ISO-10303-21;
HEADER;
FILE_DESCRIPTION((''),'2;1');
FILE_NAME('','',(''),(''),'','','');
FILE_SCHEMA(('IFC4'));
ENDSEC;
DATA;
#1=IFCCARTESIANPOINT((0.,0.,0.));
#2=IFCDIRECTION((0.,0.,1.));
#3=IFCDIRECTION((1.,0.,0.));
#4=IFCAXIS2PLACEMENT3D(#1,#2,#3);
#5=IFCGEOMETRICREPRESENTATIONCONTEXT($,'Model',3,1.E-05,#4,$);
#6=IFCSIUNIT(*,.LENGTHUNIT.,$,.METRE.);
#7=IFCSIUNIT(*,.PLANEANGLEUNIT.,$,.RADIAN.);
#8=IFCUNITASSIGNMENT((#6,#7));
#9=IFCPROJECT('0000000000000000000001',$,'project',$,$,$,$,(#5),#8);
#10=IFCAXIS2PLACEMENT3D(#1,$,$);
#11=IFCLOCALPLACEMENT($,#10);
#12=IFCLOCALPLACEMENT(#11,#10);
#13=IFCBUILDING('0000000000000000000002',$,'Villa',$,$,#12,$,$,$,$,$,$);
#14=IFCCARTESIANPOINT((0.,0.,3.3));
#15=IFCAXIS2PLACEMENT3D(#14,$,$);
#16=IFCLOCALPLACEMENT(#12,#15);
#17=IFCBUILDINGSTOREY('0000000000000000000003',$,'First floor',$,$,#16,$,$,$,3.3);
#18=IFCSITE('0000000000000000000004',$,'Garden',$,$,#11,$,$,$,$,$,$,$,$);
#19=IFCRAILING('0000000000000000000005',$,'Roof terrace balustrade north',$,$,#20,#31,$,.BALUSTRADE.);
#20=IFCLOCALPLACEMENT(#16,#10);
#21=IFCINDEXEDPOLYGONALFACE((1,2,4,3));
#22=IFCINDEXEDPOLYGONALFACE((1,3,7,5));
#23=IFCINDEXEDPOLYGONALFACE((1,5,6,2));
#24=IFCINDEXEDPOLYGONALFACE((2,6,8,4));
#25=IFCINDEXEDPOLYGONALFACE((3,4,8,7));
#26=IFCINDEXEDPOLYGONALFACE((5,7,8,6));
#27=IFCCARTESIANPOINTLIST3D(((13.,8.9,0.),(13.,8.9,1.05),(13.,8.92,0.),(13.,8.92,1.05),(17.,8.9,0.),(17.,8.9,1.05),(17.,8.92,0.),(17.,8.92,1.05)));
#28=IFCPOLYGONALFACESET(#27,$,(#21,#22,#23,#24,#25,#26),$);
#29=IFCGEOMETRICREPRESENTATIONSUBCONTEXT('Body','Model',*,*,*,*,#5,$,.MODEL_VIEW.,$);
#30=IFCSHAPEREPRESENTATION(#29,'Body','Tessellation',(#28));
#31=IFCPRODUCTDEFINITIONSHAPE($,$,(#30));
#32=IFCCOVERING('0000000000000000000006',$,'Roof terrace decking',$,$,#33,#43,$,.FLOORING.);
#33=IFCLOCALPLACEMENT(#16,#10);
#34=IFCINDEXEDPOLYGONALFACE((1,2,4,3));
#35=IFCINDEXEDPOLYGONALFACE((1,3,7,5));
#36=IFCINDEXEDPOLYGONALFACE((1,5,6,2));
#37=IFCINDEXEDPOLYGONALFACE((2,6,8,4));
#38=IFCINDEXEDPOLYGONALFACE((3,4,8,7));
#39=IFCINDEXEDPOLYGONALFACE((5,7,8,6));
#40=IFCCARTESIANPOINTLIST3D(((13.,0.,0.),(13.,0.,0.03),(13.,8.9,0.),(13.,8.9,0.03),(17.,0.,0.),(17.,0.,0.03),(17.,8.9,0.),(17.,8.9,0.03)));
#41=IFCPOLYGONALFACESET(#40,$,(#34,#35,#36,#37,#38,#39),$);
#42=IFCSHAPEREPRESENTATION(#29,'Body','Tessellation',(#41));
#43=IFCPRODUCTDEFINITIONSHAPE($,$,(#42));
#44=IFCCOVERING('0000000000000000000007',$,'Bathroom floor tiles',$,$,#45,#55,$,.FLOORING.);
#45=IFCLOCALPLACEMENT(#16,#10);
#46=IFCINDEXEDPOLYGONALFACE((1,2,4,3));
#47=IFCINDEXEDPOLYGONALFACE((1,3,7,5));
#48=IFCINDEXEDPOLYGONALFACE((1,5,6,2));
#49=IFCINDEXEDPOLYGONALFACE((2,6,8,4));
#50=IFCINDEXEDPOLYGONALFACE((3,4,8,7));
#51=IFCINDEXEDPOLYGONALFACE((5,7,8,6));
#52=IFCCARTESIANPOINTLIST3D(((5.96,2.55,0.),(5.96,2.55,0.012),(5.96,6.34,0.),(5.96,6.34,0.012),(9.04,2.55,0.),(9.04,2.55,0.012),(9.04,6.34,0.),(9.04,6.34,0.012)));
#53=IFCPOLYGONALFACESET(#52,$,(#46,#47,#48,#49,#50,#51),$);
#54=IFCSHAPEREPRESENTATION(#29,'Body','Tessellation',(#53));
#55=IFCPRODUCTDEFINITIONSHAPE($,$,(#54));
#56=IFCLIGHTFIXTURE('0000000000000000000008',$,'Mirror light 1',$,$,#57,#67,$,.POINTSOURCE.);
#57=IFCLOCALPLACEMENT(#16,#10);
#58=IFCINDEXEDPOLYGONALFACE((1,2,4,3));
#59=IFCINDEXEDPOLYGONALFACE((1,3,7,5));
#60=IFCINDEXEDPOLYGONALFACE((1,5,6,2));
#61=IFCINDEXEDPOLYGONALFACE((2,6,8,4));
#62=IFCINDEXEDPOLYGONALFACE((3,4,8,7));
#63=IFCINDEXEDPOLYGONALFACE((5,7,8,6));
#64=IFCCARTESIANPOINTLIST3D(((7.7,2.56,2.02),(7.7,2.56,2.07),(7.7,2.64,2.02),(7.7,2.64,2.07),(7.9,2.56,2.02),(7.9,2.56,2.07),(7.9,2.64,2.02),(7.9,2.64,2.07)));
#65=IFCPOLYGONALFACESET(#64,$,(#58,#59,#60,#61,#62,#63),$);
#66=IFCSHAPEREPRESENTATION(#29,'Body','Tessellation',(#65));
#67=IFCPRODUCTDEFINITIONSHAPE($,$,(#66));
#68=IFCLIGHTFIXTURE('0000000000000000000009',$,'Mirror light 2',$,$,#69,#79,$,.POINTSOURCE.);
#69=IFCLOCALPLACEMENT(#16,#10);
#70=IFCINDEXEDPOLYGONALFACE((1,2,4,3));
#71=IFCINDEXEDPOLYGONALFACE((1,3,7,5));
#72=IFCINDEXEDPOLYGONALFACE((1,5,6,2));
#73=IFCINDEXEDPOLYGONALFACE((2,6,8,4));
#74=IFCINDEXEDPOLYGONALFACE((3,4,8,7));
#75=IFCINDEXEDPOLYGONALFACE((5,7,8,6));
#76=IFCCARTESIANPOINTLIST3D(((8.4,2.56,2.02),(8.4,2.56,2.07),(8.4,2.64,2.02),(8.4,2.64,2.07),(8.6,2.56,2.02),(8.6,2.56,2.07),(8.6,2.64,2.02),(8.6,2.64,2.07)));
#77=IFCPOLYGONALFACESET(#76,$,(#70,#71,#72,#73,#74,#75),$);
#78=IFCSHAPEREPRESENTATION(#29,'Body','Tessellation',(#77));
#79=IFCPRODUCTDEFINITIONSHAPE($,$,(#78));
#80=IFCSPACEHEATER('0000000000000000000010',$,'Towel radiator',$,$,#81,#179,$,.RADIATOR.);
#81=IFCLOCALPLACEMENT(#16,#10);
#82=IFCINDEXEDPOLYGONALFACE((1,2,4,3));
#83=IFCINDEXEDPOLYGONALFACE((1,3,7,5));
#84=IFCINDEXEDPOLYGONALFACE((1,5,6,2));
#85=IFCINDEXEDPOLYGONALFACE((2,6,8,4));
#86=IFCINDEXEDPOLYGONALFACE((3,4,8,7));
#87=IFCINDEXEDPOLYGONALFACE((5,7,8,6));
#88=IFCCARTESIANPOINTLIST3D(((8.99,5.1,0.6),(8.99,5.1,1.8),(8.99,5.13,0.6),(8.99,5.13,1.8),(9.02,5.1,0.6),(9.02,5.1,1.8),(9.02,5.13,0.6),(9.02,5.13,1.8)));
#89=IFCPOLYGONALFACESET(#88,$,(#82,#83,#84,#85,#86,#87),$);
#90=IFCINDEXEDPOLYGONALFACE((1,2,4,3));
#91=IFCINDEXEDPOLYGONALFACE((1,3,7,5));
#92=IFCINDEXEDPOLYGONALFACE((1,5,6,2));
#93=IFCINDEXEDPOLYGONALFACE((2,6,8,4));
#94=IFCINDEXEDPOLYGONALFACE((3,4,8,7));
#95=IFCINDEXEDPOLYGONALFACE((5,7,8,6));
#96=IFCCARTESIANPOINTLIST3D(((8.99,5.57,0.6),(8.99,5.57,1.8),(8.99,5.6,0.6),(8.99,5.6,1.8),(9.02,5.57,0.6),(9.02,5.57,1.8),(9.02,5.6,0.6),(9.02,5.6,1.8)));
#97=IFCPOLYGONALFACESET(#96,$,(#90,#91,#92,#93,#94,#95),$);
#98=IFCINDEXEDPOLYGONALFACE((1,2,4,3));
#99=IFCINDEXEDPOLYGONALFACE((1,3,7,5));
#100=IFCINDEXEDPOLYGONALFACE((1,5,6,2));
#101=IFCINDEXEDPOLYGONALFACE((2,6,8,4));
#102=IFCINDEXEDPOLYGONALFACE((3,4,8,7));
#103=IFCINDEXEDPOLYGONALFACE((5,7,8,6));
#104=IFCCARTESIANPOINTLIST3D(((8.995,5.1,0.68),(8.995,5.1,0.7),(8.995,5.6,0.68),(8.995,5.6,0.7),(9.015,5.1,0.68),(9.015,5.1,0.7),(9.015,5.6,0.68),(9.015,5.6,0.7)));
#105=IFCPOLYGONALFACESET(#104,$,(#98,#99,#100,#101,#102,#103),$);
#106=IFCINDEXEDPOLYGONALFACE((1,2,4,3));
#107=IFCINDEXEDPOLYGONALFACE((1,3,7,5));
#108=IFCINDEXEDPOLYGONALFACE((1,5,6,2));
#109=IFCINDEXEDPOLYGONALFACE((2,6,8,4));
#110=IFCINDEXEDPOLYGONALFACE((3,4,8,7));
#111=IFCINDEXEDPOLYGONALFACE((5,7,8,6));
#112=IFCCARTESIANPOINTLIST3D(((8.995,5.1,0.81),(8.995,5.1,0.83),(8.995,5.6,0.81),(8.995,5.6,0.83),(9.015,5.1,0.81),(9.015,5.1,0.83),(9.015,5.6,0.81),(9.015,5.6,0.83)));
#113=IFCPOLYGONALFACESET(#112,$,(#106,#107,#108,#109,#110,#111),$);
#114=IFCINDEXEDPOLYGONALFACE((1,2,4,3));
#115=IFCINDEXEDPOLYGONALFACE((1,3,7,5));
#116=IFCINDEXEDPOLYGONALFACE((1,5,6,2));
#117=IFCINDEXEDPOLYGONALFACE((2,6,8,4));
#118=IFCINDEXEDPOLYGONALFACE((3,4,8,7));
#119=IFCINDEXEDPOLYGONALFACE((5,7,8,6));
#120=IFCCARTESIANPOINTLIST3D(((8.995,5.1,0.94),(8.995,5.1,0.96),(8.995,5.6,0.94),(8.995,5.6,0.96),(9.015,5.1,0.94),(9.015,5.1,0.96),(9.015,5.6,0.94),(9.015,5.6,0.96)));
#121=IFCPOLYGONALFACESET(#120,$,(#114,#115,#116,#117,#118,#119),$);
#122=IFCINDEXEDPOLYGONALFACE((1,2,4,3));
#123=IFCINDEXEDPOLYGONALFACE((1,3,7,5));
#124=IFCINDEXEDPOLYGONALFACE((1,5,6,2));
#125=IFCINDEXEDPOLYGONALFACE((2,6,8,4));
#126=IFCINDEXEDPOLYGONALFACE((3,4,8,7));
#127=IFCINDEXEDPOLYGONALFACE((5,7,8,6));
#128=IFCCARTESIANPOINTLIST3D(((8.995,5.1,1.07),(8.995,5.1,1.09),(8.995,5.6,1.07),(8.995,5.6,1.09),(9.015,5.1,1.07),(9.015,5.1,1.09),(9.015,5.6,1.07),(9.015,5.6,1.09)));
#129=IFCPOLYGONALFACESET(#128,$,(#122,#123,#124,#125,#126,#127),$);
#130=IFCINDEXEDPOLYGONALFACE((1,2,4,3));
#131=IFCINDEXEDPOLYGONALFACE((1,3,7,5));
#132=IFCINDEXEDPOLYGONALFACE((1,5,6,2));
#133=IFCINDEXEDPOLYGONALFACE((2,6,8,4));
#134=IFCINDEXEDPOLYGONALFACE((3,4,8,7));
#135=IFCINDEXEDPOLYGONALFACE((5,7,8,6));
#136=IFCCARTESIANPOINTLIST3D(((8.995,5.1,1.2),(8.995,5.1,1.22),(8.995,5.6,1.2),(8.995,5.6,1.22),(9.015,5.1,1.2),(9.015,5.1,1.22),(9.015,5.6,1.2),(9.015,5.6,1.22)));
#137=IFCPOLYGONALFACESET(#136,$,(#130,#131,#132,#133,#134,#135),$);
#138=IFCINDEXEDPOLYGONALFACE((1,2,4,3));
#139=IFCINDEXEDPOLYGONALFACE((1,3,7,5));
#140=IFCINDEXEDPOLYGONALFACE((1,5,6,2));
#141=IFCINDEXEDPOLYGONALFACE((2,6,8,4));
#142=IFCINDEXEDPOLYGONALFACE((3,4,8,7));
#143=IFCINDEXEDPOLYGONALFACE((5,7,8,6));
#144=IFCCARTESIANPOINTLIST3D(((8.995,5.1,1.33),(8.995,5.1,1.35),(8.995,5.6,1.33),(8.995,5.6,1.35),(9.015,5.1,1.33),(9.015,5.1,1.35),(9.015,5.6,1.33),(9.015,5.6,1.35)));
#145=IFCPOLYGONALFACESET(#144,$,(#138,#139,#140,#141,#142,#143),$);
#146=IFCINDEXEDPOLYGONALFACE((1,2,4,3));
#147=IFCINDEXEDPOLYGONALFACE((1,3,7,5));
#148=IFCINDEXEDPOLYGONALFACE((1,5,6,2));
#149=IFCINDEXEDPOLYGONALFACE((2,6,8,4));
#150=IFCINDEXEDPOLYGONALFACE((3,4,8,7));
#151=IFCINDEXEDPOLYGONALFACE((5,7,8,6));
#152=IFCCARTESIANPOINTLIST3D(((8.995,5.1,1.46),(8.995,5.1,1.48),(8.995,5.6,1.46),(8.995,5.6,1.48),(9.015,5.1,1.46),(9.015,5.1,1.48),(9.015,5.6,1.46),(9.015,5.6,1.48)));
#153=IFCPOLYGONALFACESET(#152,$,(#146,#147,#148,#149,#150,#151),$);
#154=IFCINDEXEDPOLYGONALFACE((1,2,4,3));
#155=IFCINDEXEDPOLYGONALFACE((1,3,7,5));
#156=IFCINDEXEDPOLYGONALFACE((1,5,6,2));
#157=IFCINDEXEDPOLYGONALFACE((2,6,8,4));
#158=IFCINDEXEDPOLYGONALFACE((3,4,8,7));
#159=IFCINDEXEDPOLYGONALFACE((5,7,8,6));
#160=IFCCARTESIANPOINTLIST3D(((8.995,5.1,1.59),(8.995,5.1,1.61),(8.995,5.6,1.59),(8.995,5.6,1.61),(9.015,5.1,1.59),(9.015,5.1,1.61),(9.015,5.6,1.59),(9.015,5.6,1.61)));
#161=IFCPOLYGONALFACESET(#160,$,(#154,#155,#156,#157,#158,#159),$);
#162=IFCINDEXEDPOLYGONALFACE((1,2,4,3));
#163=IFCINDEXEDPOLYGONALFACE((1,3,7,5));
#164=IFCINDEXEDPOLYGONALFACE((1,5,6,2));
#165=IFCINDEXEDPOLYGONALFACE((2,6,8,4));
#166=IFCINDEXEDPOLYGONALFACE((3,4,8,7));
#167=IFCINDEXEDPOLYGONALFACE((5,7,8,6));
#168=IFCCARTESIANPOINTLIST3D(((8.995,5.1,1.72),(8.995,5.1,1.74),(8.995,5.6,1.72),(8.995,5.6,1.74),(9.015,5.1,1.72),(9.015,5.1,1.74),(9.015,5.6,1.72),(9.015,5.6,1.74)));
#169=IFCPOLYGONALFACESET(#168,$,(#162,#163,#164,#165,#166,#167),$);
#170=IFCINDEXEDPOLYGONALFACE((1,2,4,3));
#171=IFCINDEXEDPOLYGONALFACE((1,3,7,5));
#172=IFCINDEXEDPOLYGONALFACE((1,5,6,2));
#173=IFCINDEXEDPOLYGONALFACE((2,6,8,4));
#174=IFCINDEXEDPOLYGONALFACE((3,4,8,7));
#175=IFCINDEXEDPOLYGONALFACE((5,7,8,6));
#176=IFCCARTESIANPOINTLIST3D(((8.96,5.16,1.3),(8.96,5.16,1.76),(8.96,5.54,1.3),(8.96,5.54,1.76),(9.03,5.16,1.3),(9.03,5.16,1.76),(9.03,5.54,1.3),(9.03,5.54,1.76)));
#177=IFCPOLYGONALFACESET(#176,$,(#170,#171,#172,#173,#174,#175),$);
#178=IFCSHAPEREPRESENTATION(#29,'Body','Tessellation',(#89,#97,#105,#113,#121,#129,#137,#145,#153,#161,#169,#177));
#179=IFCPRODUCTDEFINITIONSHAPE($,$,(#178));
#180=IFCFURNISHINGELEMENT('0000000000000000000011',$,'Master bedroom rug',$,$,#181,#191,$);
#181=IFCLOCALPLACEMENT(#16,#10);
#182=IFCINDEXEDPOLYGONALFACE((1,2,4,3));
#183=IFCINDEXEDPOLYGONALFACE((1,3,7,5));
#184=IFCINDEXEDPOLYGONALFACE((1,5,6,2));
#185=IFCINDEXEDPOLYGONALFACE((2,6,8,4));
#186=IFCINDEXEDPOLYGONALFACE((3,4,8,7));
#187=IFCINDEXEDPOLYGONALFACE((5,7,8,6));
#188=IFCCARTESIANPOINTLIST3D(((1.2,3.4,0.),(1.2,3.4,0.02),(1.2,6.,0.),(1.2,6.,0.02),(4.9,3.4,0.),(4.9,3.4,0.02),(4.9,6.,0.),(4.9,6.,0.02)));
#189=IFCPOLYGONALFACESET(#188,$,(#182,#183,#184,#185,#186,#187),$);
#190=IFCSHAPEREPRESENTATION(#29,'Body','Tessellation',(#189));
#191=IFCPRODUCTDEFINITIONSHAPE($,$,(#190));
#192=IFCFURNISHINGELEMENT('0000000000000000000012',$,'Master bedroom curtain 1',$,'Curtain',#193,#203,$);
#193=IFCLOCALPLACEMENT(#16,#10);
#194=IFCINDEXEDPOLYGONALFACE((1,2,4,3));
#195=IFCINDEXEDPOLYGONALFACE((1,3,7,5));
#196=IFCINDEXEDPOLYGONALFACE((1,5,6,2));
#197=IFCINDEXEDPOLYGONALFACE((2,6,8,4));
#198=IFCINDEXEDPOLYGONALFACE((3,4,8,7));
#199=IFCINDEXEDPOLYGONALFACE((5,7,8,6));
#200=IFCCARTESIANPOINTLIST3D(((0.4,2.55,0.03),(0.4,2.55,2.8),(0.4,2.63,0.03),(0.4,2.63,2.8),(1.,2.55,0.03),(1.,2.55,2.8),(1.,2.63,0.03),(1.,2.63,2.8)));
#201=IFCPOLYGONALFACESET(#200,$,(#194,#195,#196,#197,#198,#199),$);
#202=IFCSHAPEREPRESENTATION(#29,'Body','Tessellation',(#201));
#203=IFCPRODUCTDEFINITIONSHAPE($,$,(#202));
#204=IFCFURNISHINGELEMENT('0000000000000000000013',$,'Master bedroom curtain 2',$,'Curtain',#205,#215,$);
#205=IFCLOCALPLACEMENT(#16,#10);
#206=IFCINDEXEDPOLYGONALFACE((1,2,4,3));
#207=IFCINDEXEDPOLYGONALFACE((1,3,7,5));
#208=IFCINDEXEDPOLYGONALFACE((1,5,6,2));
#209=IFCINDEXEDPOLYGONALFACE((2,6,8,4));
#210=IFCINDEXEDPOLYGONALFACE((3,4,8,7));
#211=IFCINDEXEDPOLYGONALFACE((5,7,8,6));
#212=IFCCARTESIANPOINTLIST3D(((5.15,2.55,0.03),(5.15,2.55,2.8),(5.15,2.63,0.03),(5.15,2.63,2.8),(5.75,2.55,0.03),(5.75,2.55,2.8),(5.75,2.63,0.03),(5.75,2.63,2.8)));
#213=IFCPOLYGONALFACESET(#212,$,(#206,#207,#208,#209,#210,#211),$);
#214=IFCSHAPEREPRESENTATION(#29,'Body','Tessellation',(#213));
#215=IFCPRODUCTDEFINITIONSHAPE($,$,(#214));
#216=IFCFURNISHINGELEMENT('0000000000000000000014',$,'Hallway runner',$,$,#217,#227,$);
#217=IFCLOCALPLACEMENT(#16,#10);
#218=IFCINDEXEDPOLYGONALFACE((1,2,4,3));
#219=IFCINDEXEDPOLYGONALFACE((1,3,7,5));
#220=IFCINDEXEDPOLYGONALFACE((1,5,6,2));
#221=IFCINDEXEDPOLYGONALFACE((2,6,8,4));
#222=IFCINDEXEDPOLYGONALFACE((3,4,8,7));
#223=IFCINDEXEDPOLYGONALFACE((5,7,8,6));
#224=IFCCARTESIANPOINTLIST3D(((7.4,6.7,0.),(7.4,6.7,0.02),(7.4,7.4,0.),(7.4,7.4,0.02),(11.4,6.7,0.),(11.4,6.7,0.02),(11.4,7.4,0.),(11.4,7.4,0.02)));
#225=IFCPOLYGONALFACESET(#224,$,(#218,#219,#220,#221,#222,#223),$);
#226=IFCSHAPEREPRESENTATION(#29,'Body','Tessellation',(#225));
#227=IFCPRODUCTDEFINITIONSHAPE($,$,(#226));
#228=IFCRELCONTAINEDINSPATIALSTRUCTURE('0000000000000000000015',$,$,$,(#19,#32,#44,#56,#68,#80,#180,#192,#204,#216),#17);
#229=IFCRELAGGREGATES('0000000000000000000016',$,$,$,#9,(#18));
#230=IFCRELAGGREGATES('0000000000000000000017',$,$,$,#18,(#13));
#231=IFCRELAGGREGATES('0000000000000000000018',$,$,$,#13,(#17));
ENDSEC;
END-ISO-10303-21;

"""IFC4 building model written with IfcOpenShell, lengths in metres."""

from ifc_helpers import new_model, si_unit, frame, frame_2d, origin, origin_with_axes, place, context, subcontext, project, spatial, rectangle, extrude, element, save


model = new_model("IFC4")

# Units and contexts
model_context = context("Model", 3, precision=1e-05, world=origin_with_axes())
body_context = subcontext(model_context, "Body", "Model", "MODEL_VIEW")
ifc_project = project(units=[si_unit("LENGTHUNIT", "METRE"), si_unit("PLANEANGLEUNIT", "RADIAN")], contexts=[model_context])

# Site, building, storey
site_placement = place(None, origin())
site = spatial("IfcSite", under=ifc_project, at=site_placement, Name="Garden")
building_placement = place(site_placement, origin())
building = spatial("IfcBuilding", under=site, at=building_placement, Name="Villa")
storey_placement = place(building_placement, frame((0.0, 0.0, 3.3)))
storey = spatial("IfcBuildingStorey", under=building, at=storey_placement, Name="First floor", Elevation=3.3)

# Railing
railing_1_placement = place(storey_placement, origin())
element("IfcRailing", 1, at=railing_1_placement, inside=storey, Name="Roof terrace balustrade north", PredefinedType="BALUSTRADE", context=body_context, shape_type="SweptSolid", body=[
    extrude(rectangle(XDim=4.0, YDim=0.02, at=frame_2d((2.0, 0.01))), frame((13.0, 8.9, 0.0)), (0.0, 0.0, 1.0), 1.05),
])

# Coverings
covering_1_placement = place(storey_placement, origin())
element("IfcCovering", 2, at=covering_1_placement, inside=storey, Name="Roof terrace decking", PredefinedType="FLOORING", context=body_context, shape_type="SweptSolid", body=[
    extrude(rectangle(XDim=4.0, YDim=8.9, at=frame_2d((2.0, 4.45))), frame((13.0, 0.0, 0.0)), (0.0, 0.0, 1.0), 0.03),
])
covering_2_placement = place(storey_placement, origin())
element("IfcCovering", 3, at=covering_2_placement, inside=storey, Name="Bathroom floor tiles", PredefinedType="FLOORING", context=body_context, shape_type="SweptSolid", body=[
    extrude(rectangle(XDim=3.08, YDim=3.79, at=frame_2d((1.54, 1.895))), frame((5.96, 2.55, 0.0)), (0.0, 0.0, 1.0), 0.012),
])

# Light fixtures
light_fixture_1_placement = place(storey_placement, origin())
element("IfcLightFixture", 4, at=light_fixture_1_placement, inside=storey, Name="Mirror light 1", PredefinedType="POINTSOURCE", context=body_context, shape_type="SweptSolid", body=[
    extrude(rectangle(XDim=0.2, YDim=0.08, at=frame_2d((0.1, 0.04))), frame((7.7, 2.56, 2.02)), (0.0, 0.0, 1.0), 0.05),
])
light_fixture_2_placement = place(storey_placement, origin())
element("IfcLightFixture", 5, at=light_fixture_2_placement, inside=storey, Name="Mirror light 2", PredefinedType="POINTSOURCE", context=body_context, shape_type="SweptSolid", body=[
    extrude(rectangle(XDim=0.2, YDim=0.08, at=frame_2d((0.1, 0.04))), frame((8.4, 2.56, 2.02)), (0.0, 0.0, 1.0), 0.05),
])

# Space heater
space_heater_placement = place(storey_placement, origin())
element("IfcSpaceHeater", 6, at=space_heater_placement, inside=storey, Name="Towel radiator", PredefinedType="RADIATOR", context=body_context, shape_type="SweptSolid", body=[
    extrude(rectangle(XDim=0.03, YDim=0.03, at=frame_2d((0.015, 0.015))), frame((8.99, 5.1, 0.6)), (0.0, 0.0, 1.0), 1.2),
    extrude(rectangle(XDim=0.03, YDim=0.03, at=frame_2d((0.015, 0.015))), frame((8.99, 5.57, 0.6)), (0.0, 0.0, 1.0), 1.2),
    extrude(rectangle(XDim=0.02, YDim=0.5, at=frame_2d((0.01, 0.25))), frame((8.995, 5.1, 0.68)), (0.0, 0.0, 1.0), 0.02),
    extrude(rectangle(XDim=0.02, YDim=0.5, at=frame_2d((0.01, 0.25))), frame((8.995, 5.1, 0.81)), (0.0, 0.0, 1.0), 0.02),
    extrude(rectangle(XDim=0.02, YDim=0.5, at=frame_2d((0.01, 0.25))), frame((8.995, 5.1, 0.94)), (0.0, 0.0, 1.0), 0.02),
    extrude(rectangle(XDim=0.02, YDim=0.5, at=frame_2d((0.01, 0.25))), frame((8.995, 5.1, 1.07)), (0.0, 0.0, 1.0), 0.02),
    extrude(rectangle(XDim=0.02, YDim=0.5, at=frame_2d((0.01, 0.25))), frame((8.995, 5.1, 1.2)), (0.0, 0.0, 1.0), 0.02),
    extrude(rectangle(XDim=0.02, YDim=0.5, at=frame_2d((0.01, 0.25))), frame((8.995, 5.1, 1.33)), (0.0, 0.0, 1.0), 0.02),
    extrude(rectangle(XDim=0.02, YDim=0.5, at=frame_2d((0.01, 0.25))), frame((8.995, 5.1, 1.46)), (0.0, 0.0, 1.0), 0.02),
    extrude(rectangle(XDim=0.02, YDim=0.5, at=frame_2d((0.01, 0.25))), frame((8.995, 5.1, 1.59)), (0.0, 0.0, 1.0), 0.02),
    extrude(rectangle(XDim=0.02, YDim=0.5, at=frame_2d((0.01, 0.25))), frame((8.995, 5.1, 1.72)), (0.0, 0.0, 1.0), 0.02),
    extrude(rectangle(XDim=0.07, YDim=0.38, at=frame_2d((0.035, 0.19))), frame((8.96, 5.16, 1.3)), (0.0, 0.0, 1.0), 0.46),
])

# Furnishing elements
furnishing_1_placement = place(storey_placement, origin())
element("IfcFurnishingElement", 7, at=furnishing_1_placement, inside=storey, Name="Master bedroom rug", context=body_context, shape_type="SweptSolid", body=[
    extrude(rectangle(XDim=3.7, YDim=2.6, at=frame_2d((1.85, 1.3))), frame((1.2, 3.4, 0.0)), (0.0, 0.0, 1.0), 0.02),
])
furnishing_2_placement = place(storey_placement, origin())
element("IfcFurnishingElement", 8, at=furnishing_2_placement, inside=storey, Name="Master bedroom curtain 1", ObjectType="Curtain", context=body_context, shape_type="SweptSolid", body=[
    extrude(rectangle(XDim=0.6, YDim=0.08, at=frame_2d((0.3, 0.04))), frame((0.4, 2.55, 0.03)), (0.0, 0.0, 1.0), 2.77),
])
furnishing_3_placement = place(storey_placement, origin())
element("IfcFurnishingElement", 9, at=furnishing_3_placement, inside=storey, Name="Master bedroom curtain 2", ObjectType="Curtain", context=body_context, shape_type="SweptSolid", body=[
    extrude(rectangle(XDim=0.6, YDim=0.08, at=frame_2d((0.3, 0.04))), frame((5.15, 2.55, 0.03)), (0.0, 0.0, 1.0), 2.77),
])
furnishing_4_placement = place(storey_placement, origin())
element("IfcFurnishingElement", 10, at=furnishing_4_placement, inside=storey, Name="Hallway runner", context=body_context, shape_type="SweptSolid", body=[
    extrude(rectangle(XDim=4.0, YDim=0.7, at=frame_2d((2.0, 0.35))), frame((7.4, 6.7, 0.0)), (0.0, 0.0, 1.0), 0.02),
])

save(model, "model.ifc")
